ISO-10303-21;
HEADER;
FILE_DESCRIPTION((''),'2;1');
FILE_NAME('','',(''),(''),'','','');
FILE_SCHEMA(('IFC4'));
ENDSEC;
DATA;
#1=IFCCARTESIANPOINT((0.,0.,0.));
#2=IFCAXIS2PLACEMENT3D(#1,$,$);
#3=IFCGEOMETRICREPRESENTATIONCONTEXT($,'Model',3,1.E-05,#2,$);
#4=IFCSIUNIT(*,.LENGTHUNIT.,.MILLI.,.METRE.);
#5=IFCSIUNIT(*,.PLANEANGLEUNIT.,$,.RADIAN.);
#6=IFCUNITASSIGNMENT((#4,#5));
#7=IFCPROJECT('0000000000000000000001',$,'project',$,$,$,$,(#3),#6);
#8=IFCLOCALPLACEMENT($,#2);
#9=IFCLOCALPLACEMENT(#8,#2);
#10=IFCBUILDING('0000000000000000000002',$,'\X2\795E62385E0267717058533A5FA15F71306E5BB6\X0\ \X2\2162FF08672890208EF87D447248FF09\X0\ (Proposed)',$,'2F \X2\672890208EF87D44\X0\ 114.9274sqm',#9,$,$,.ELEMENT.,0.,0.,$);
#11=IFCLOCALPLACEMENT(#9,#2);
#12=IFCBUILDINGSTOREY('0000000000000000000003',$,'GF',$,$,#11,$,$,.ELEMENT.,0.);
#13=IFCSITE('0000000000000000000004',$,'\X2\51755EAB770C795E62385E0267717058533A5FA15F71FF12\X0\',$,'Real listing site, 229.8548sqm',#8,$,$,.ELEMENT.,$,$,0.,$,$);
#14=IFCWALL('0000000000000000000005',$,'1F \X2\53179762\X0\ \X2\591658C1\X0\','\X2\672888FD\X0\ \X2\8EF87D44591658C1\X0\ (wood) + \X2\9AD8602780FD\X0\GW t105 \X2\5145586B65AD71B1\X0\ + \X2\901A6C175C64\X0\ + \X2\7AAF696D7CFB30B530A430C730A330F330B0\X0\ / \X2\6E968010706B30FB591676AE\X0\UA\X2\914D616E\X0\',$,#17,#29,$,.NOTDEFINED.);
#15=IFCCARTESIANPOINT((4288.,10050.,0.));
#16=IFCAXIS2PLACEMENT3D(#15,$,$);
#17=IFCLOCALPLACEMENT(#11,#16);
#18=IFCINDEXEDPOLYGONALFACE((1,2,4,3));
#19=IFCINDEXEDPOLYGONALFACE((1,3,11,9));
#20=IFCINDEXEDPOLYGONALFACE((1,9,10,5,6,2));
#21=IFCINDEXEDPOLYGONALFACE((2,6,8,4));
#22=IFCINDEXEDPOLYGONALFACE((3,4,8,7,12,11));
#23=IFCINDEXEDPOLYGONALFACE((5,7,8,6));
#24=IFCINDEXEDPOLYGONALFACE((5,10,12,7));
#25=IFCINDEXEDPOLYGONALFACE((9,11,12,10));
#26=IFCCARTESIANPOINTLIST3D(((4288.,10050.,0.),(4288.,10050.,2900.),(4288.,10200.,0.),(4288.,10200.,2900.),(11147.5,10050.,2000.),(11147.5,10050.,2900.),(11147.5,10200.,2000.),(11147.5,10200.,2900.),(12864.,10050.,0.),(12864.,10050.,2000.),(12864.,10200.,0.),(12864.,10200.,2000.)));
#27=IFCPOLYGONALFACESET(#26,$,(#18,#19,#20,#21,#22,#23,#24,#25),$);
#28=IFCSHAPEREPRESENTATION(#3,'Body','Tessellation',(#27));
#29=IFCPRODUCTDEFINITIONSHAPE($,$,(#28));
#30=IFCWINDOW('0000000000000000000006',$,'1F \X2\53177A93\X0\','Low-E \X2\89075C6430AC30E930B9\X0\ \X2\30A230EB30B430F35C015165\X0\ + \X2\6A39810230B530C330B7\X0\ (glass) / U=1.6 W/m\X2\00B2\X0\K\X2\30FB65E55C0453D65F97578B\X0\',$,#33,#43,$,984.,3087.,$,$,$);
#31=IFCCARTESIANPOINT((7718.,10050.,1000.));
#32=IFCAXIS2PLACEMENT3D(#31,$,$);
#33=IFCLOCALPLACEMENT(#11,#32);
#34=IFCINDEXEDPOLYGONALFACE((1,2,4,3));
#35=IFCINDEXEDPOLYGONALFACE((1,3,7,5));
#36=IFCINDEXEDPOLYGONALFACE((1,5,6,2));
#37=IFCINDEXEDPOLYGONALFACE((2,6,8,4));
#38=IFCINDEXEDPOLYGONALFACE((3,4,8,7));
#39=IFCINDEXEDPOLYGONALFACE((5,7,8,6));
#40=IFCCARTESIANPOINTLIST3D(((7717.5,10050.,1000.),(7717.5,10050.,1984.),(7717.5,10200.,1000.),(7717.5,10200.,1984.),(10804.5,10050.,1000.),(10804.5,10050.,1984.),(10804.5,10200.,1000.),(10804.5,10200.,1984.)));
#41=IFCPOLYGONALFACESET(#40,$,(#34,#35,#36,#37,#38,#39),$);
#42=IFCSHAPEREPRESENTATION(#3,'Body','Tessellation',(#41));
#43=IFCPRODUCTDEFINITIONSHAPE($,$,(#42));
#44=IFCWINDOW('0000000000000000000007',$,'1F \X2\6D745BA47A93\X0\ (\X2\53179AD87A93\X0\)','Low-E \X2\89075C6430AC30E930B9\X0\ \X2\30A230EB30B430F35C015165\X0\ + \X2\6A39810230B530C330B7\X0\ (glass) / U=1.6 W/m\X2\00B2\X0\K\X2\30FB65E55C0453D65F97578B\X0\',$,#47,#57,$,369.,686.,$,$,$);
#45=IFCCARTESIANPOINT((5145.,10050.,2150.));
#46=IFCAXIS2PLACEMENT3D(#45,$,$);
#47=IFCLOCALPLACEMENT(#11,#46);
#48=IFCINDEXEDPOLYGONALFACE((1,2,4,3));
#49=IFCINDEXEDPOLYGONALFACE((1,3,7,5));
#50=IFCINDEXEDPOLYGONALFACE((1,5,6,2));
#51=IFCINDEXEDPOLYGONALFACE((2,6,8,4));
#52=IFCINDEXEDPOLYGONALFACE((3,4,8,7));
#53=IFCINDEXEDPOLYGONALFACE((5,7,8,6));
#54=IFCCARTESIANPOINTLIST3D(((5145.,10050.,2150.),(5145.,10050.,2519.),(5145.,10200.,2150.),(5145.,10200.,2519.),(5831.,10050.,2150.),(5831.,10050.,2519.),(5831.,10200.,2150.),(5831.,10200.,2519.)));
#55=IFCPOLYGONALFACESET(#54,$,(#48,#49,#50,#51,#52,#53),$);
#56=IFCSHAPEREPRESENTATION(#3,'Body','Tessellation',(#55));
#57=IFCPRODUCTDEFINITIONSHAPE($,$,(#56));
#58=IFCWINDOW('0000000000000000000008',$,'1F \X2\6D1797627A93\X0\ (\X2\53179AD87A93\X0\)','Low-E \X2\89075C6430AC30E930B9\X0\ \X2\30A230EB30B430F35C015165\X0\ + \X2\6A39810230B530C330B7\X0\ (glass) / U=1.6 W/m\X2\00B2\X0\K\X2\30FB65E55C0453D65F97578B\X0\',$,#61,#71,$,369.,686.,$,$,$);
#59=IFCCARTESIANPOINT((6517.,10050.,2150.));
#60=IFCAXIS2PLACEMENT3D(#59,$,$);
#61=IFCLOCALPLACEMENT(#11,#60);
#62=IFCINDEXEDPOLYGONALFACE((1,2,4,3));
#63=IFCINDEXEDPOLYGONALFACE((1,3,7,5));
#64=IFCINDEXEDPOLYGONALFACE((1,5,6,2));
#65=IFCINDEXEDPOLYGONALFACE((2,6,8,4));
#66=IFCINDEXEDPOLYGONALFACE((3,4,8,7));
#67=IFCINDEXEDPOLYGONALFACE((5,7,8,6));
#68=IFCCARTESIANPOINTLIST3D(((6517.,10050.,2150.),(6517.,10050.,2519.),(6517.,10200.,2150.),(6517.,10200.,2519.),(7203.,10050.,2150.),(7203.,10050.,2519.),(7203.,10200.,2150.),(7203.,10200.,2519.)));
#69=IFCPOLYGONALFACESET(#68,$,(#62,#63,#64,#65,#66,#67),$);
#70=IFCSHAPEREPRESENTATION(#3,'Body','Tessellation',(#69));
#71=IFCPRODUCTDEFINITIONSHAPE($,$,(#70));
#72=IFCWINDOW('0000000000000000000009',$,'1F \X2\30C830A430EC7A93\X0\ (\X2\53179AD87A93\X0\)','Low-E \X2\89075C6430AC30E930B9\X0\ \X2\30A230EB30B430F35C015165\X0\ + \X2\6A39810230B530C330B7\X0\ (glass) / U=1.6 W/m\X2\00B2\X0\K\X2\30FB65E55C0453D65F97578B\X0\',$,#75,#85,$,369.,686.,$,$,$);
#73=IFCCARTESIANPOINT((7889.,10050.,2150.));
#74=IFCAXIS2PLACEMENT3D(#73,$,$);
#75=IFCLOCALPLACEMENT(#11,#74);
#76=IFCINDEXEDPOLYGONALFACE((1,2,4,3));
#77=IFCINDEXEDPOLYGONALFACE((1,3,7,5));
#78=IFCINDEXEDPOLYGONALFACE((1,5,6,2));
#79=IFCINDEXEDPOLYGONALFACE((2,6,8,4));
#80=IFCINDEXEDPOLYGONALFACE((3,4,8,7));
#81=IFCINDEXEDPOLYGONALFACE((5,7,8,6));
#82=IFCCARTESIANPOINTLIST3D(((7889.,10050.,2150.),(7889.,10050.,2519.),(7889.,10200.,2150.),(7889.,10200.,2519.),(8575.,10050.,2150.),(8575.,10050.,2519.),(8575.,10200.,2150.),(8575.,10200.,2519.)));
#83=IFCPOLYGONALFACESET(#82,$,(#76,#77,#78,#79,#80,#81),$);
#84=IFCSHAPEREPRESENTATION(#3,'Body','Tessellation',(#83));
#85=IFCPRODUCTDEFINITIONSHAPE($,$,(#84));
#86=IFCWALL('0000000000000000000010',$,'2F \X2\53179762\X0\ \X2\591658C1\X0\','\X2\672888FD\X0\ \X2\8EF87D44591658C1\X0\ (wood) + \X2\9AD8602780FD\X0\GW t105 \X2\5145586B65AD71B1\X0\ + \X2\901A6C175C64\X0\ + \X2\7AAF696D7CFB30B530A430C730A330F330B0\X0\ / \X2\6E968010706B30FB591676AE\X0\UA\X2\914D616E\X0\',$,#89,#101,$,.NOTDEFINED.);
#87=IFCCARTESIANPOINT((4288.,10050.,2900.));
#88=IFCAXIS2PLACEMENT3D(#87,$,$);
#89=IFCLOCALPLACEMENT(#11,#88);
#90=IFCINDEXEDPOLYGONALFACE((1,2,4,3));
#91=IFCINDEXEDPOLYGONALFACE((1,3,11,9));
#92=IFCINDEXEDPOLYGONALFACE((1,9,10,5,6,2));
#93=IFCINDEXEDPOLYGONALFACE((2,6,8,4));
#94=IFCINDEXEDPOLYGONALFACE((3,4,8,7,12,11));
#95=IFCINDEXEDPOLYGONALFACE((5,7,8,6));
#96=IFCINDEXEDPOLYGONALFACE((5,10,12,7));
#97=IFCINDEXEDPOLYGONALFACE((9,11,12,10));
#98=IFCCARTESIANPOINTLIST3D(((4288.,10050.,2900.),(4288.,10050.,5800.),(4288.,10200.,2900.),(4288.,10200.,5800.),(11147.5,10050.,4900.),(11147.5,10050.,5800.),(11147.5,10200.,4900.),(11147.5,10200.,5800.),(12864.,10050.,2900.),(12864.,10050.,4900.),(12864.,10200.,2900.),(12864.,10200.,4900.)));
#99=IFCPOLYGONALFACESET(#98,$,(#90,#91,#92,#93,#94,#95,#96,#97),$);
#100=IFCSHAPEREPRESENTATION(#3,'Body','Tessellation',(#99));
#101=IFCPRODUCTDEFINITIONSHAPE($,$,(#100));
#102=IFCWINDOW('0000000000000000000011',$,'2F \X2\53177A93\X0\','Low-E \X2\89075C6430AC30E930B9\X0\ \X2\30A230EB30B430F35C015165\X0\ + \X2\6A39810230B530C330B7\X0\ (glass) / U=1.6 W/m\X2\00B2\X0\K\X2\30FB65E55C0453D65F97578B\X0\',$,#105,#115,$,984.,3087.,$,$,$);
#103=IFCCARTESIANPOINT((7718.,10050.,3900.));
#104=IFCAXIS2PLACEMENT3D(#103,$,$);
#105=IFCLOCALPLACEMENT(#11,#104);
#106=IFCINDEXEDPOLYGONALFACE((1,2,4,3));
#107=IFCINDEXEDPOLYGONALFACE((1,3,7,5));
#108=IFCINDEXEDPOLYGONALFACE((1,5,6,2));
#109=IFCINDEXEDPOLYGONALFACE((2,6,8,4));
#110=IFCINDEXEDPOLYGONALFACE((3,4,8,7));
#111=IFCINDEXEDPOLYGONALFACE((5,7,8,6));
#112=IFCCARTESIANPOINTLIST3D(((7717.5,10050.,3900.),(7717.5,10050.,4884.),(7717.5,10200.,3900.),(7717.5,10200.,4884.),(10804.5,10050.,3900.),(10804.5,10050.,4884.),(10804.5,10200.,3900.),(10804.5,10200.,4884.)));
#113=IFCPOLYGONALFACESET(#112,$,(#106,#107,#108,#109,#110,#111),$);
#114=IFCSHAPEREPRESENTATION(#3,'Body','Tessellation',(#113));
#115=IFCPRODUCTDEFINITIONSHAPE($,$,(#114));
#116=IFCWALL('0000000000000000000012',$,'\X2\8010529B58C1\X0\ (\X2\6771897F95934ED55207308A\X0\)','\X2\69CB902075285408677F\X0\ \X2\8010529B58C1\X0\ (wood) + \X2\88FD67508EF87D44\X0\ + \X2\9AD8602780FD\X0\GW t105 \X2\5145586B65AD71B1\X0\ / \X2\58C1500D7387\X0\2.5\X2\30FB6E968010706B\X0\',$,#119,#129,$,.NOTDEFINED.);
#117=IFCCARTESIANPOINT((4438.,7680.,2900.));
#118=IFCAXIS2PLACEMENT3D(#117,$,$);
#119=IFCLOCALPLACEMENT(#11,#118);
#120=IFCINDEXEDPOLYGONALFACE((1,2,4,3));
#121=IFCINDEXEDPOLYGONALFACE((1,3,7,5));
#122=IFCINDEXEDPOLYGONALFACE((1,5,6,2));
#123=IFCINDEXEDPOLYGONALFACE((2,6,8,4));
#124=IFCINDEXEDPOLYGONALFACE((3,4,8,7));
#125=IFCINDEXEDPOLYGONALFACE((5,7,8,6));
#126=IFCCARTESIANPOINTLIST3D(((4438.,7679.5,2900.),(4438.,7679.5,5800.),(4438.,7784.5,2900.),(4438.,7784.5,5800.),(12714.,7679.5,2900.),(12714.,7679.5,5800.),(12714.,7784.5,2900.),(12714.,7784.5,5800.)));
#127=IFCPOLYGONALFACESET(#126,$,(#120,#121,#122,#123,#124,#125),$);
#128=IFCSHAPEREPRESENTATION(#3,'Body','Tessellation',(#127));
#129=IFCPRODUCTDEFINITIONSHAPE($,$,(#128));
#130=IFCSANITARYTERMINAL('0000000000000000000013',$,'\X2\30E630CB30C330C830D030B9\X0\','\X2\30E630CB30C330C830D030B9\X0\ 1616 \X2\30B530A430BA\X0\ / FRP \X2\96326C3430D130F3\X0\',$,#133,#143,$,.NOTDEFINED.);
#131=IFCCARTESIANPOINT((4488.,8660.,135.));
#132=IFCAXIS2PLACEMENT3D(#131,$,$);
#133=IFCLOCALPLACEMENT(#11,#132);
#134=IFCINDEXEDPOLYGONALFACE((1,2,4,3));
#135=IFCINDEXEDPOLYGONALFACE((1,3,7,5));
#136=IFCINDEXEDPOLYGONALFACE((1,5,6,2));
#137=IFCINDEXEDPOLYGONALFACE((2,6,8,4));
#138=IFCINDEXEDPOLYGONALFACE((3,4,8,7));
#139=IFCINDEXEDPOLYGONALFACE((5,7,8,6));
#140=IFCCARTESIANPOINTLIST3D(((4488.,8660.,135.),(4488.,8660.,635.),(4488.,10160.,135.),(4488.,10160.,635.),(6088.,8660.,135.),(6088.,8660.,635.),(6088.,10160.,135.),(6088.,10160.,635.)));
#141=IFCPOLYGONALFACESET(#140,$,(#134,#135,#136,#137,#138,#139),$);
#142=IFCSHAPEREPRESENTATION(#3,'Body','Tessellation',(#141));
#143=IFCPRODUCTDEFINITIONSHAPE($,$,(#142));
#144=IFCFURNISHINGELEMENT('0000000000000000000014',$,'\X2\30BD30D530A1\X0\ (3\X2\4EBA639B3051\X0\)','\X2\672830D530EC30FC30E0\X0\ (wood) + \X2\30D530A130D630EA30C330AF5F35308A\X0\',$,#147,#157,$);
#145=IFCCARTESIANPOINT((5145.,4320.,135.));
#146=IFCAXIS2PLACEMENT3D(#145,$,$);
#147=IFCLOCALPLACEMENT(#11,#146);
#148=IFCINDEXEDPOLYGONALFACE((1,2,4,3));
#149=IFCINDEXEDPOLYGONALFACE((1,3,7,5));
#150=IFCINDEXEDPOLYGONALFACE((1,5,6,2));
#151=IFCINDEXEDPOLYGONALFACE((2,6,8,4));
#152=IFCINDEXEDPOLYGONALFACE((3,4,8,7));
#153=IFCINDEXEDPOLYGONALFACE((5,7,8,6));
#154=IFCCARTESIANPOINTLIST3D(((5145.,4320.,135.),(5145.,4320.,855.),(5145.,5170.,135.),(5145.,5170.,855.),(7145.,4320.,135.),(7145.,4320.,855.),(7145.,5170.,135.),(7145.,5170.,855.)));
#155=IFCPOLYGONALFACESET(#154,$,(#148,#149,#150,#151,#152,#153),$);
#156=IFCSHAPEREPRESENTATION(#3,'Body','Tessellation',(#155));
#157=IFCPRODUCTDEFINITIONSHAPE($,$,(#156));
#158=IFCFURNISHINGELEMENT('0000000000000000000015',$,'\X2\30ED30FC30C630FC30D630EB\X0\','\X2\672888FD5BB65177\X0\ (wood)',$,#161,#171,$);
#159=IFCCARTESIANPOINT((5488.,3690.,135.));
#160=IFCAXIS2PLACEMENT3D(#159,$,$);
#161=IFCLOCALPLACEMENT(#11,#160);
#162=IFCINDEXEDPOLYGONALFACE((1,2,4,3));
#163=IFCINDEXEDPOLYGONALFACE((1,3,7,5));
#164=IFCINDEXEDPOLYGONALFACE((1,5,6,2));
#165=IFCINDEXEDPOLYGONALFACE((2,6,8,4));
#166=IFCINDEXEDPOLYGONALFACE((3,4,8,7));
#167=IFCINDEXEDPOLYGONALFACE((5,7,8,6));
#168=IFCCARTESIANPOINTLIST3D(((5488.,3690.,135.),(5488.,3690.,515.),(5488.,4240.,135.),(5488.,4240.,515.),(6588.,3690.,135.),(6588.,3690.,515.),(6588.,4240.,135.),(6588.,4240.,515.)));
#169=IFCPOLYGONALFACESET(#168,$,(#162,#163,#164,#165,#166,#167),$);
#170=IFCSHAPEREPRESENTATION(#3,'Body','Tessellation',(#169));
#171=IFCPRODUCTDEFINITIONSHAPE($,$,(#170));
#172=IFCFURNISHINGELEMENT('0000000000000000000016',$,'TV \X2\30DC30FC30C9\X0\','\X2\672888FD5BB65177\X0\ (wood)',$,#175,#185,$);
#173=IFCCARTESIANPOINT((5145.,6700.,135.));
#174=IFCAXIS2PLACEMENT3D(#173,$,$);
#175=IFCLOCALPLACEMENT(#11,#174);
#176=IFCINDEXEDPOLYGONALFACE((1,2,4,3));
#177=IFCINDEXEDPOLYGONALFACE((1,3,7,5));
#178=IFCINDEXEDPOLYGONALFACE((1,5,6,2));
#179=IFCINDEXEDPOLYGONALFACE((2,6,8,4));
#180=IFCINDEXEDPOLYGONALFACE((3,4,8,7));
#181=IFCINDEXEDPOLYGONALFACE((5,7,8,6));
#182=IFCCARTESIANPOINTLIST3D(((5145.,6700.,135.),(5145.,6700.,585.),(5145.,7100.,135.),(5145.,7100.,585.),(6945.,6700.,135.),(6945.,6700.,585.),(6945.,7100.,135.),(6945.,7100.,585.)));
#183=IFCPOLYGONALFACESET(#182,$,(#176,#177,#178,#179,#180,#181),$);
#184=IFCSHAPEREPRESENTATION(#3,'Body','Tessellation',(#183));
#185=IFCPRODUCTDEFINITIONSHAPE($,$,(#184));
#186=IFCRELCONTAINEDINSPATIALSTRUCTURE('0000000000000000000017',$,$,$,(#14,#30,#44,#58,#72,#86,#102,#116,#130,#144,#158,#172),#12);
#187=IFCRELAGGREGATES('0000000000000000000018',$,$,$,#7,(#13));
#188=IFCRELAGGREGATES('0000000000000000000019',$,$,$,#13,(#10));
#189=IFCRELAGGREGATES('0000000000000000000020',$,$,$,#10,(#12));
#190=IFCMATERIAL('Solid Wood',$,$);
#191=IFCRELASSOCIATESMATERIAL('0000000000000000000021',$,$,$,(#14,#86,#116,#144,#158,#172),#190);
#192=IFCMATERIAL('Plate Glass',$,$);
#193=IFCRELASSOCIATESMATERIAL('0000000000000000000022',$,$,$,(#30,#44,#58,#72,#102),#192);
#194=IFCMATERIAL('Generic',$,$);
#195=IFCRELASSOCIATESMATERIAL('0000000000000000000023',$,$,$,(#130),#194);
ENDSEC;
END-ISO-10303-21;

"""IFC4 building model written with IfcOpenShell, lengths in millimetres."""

from ifc_helpers import new_model, si_unit, frame, frame_2d, origin, place, context, project, spatial, rectangle, extrude, material, element, fill, save


model = new_model("IFC4")

# Units and contexts
model_context = context("Model", 3, precision=1e-05, world=origin())
ifc_project = project(units=[si_unit("LENGTHUNIT", "METRE", prefix="MILLI"), si_unit("PLANEANGLEUNIT", "RADIAN")], contexts=[model_context])

# Site, building, storey
site_placement = place(None, origin())
site = spatial("IfcSite", under=ifc_project, at=site_placement, Name="兵庫県神戸市東灘区御影２", ObjectType="Real listing site, 229.8548sqm", CompositionType="ELEMENT", RefElevation=0.0)
building_placement = place(site_placement, origin())
building = spatial("IfcBuilding", under=site, at=building_placement, Name="神戸市東灘区御影の家 Ⅲ（木造軸組版） (Proposed)", ObjectType="2F 木造軸組 114.9274sqm", CompositionType="ELEMENT", ElevationOfRefHeight=0.0, ElevationOfTerrain=0.0)
storey_placement = place(building_placement, origin())
storey = spatial("IfcBuildingStorey", under=building, at=storey_placement, Name="GF", CompositionType="ELEMENT", Elevation=0.0)

# Wall, openings, windows
ifc_material_1 = material(Name="Solid Wood")
wall_1_placement = place(storey_placement, frame((4288.0, 10050.0, 0.0)))
wall_1 = element("IfcWall", 1, at=wall_1_placement, inside=storey, material=ifc_material_1, Name="1F 北面 外壁", Description="木製 軸組外壁 (wood) + 高性能GW t105 充填断熱 + 通気層 + 窯業系サイディング / 準耐火・外皮UA配慮", PredefinedType="NOTDEFINED", context=model_context, shape_type="SweptSolid", body=[
    extrude(rectangle(XDim=8576.0, YDim=150.0, at=frame_2d((4288.0, 75.0))), frame((4288.0, 10050.0, 0.0)), (0.0, 0.0, 1.0), 2900.0),
])
opening_1_placement = place(storey_placement, frame((7718.0, 10050.0, 1000.0)))
opening_1 = element("IfcOpeningElement", 2, at=opening_1_placement, cuts=wall_1, PredefinedType="NOTDEFINED", context=model_context, shape_type="SweptSolid", body=[
    extrude(rectangle(XDim=3087.0, YDim=150.0, at=frame_2d((1543.0, 75.0))), frame((7718.0, 10050.0, 1000.0)), (0.0, 0.0, 1.0), 984.0),
])
opening_2_placement = place(storey_placement, frame((5145.0, 10050.0, 2150.0)))
opening_2 = element("IfcOpeningElement", 3, at=opening_2_placement, cuts=wall_1, PredefinedType="NOTDEFINED", context=model_context, shape_type="SweptSolid", body=[
    extrude(rectangle(XDim=686.0, YDim=150.0, at=frame_2d((343.0, 75.0))), frame((5145.0, 10050.0, 2150.0)), (0.0, 0.0, 1.0), 369.0),
])
opening_3_placement = place(storey_placement, frame((6517.0, 10050.0, 2150.0)))
opening_3 = element("IfcOpeningElement", 4, at=opening_3_placement, cuts=wall_1, PredefinedType="NOTDEFINED", context=model_context, shape_type="SweptSolid", body=[
    extrude(rectangle(XDim=686.0, YDim=150.0, at=frame_2d((343.0, 75.0))), frame((6517.0, 10050.0, 2150.0)), (0.0, 0.0, 1.0), 369.0),
])
opening_4_placement = place(storey_placement, frame((7889.0, 10050.0, 2150.0)))
opening_4 = element("IfcOpeningElement", 5, at=opening_4_placement, cuts=wall_1, PredefinedType="NOTDEFINED", context=model_context, shape_type="SweptSolid", body=[
    extrude(rectangle(XDim=686.0, YDim=150.0, at=frame_2d((343.0, 75.0))), frame((7889.0, 10050.0, 2150.0)), (0.0, 0.0, 1.0), 369.0),
])
ifc_material_2 = material(Name="Plate Glass")
window_1_placement = place(storey_placement, frame((7718.0, 10050.0, 1000.0)))
window_1 = element("IfcWindow", 6, at=window_1_placement, inside=storey, material=ifc_material_2, Name="1F 北窓", Description="Low-E 複層ガラス アルゴン封入 + 樹脂サッシ (glass) / U=1.6 W/m²K・日射取得型", OverallHeight=984.0, OverallWidth=3087.0, context=model_context, shape_type="SweptSolid", body=[
    extrude(rectangle(XDim=3087.0, YDim=150.0, at=frame_2d((1543.0, 75.0))), frame((7718.0, 10050.0, 1000.0)), (0.0, 0.0, 1.0), 984.0),
])
fill(opening_1, window_1)
window_2_placement = place(storey_placement, frame((5145.0, 10050.0, 2150.0)))
window_2 = element("IfcWindow", 7, at=window_2_placement, inside=storey, material=ifc_material_2, Name="1F 浴室窓 (北高窓)", Description="Low-E 複層ガラス アルゴン封入 + 樹脂サッシ (glass) / U=1.6 W/m²K・日射取得型", OverallHeight=369.0, OverallWidth=686.0, context=model_context, shape_type="SweptSolid", body=[
    extrude(rectangle(XDim=686.0, YDim=150.0, at=frame_2d((343.0, 75.0))), frame((5145.0, 10050.0, 2150.0)), (0.0, 0.0, 1.0), 369.0),
])
fill(opening_2, window_2)
window_3_placement = place(storey_placement, frame((6517.0, 10050.0, 2150.0)))
window_3 = element("IfcWindow", 8, at=window_3_placement, inside=storey, material=ifc_material_2, Name="1F 洗面窓 (北高窓)", Description="Low-E 複層ガラス アルゴン封入 + 樹脂サッシ (glass) / U=1.6 W/m²K・日射取得型", OverallHeight=369.0, OverallWidth=686.0, context=model_context, shape_type="SweptSolid", body=[
    extrude(rectangle(XDim=686.0, YDim=150.0, at=frame_2d((343.0, 75.0))), frame((6517.0, 10050.0, 2150.0)), (0.0, 0.0, 1.0), 369.0),
])
fill(opening_3, window_3)
window_4_placement = place(storey_placement, frame((7889.0, 10050.0, 2150.0)))
window_4 = element("IfcWindow", 9, at=window_4_placement, inside=storey, material=ifc_material_2, Name="1F トイレ窓 (北高窓)", Description="Low-E 複層ガラス アルゴン封入 + 樹脂サッシ (glass) / U=1.6 W/m²K・日射取得型", OverallHeight=369.0, OverallWidth=686.0, context=model_context, shape_type="SweptSolid", body=[
    extrude(rectangle(XDim=686.0, YDim=150.0, at=frame_2d((343.0, 75.0))), frame((7889.0, 10050.0, 2150.0)), (0.0, 0.0, 1.0), 369.0),
])
fill(opening_4, window_4)

# Wall, opening, window
wall_2_placement = place(storey_placement, frame((4288.0, 10050.0, 2900.0)))
wall_2 = element("IfcWall", 10, at=wall_2_placement, inside=storey, material=ifc_material_1, Name="2F 北面 外壁", Description="木製 軸組外壁 (wood) + 高性能GW t105 充填断熱 + 通気層 + 窯業系サイディング / 準耐火・外皮UA配慮", PredefinedType="NOTDEFINED", context=model_context, shape_type="SweptSolid", body=[
    extrude(rectangle(XDim=8576.0, YDim=150.0, at=frame_2d((4288.0, 75.0))), frame((4288.0, 10050.0, 2900.0)), (0.0, 0.0, 1.0), 2900.0),
])
opening_5_placement = place(storey_placement, frame((7718.0, 10050.0, 3900.0)))
opening_5 = element("IfcOpeningElement", 11, at=opening_5_placement, cuts=wall_2, PredefinedType="NOTDEFINED", context=model_context, shape_type="SweptSolid", body=[
    extrude(rectangle(XDim=3087.0, YDim=150.0, at=frame_2d((1543.0, 75.0))), frame((7718.0, 10050.0, 3900.0)), (0.0, 0.0, 1.0), 984.0),
])
window_5_placement = place(storey_placement, frame((7718.0, 10050.0, 3900.0)))
window_5 = element("IfcWindow", 12, at=window_5_placement, inside=storey, material=ifc_material_2, Name="2F 北窓", Description="Low-E 複層ガラス アルゴン封入 + 樹脂サッシ (glass) / U=1.6 W/m²K・日射取得型", OverallHeight=984.0, OverallWidth=3087.0, context=model_context, shape_type="SweptSolid", body=[
    extrude(rectangle(XDim=3087.0, YDim=150.0, at=frame_2d((1543.0, 75.0))), frame((7718.0, 10050.0, 3900.0)), (0.0, 0.0, 1.0), 984.0),
])
fill(opening_5, window_5)

# Wall
wall_3_placement = place(storey_placement, frame((4438.0, 7680.0, 2900.0)))
element("IfcWall", 13, at=wall_3_placement, inside=storey, material=ifc_material_1, Name="耐力壁 (東西間仕切り)", Description="構造用合板 耐力壁 (wood) + 製材軸組 + 高性能GW t105 充填断熱 / 壁倍率2.5・準耐火", PredefinedType="NOTDEFINED", context=model_context, shape_type="SweptSolid", body=[
    extrude(rectangle(XDim=8276.0, YDim=105.0, at=frame_2d((4138.0, 52.0))), frame((4438.0, 7680.0, 2900.0)), (0.0, 0.0, 1.0), 2900.0),
])

# Sanitary terminal
ifc_material_3 = material(Name="Generic")
sanitary_terminal_placement = place(storey_placement, frame((4488.0, 8660.0, 135.0)))
element("IfcSanitaryTerminal", 14, at=sanitary_terminal_placement, inside=storey, material=ifc_material_3, Name="ユニットバス", Description="ユニットバス 1616 サイズ / FRP 防水パン", PredefinedType="NOTDEFINED", context=model_context, shape_type="SweptSolid", body=[
    extrude(rectangle(XDim=1600.0, YDim=1500.0, at=frame_2d((800.0, 750.0))), frame((4488.0, 8660.0, 135.0)), (0.0, 0.0, 1.0), 500.0),
])

# Furnishing elements
furnishing_1_placement = place(storey_placement, frame((5145.0, 4320.0, 135.0)))
element("IfcFurnishingElement", 15, at=furnishing_1_placement, inside=storey, material=ifc_material_1, Name="ソファ (3人掛け)", Description="木フレーム (wood) + ファブリック張り", context=model_context, shape_type="SweptSolid", body=[
    extrude(rectangle(XDim=2000.0, YDim=850.0, at=frame_2d((1000.0, 425.0))), frame((5145.0, 4320.0, 135.0)), (0.0, 0.0, 1.0), 720.0),
])
furnishing_2_placement = place(storey_placement, frame((5488.0, 3690.0, 135.0)))
element("IfcFurnishingElement", 16, at=furnishing_2_placement, inside=storey, material=ifc_material_1, Name="ローテーブル", Description="木製家具 (wood)", context=model_context, shape_type="SweptSolid", body=[
    extrude(rectangle(XDim=1100.0, YDim=550.0, at=frame_2d((550.0, 275.0))), frame((5488.0, 3690.0, 135.0)), (0.0, 0.0, 1.0), 380.0),
])
furnishing_3_placement = place(storey_placement, frame((5145.0, 6700.0, 135.0)))
element("IfcFurnishingElement", 17, at=furnishing_3_placement, inside=storey, material=ifc_material_1, Name="TV ボード", Description="木製家具 (wood)", context=model_context, shape_type="SweptSolid", body=[
    extrude(rectangle(XDim=1800.0, YDim=400.0, at=frame_2d((900.0, 200.0))), frame((5145.0, 6700.0, 135.0)), (0.0, 0.0, 1.0), 450.0),
])

save(model, "model.ifc")
